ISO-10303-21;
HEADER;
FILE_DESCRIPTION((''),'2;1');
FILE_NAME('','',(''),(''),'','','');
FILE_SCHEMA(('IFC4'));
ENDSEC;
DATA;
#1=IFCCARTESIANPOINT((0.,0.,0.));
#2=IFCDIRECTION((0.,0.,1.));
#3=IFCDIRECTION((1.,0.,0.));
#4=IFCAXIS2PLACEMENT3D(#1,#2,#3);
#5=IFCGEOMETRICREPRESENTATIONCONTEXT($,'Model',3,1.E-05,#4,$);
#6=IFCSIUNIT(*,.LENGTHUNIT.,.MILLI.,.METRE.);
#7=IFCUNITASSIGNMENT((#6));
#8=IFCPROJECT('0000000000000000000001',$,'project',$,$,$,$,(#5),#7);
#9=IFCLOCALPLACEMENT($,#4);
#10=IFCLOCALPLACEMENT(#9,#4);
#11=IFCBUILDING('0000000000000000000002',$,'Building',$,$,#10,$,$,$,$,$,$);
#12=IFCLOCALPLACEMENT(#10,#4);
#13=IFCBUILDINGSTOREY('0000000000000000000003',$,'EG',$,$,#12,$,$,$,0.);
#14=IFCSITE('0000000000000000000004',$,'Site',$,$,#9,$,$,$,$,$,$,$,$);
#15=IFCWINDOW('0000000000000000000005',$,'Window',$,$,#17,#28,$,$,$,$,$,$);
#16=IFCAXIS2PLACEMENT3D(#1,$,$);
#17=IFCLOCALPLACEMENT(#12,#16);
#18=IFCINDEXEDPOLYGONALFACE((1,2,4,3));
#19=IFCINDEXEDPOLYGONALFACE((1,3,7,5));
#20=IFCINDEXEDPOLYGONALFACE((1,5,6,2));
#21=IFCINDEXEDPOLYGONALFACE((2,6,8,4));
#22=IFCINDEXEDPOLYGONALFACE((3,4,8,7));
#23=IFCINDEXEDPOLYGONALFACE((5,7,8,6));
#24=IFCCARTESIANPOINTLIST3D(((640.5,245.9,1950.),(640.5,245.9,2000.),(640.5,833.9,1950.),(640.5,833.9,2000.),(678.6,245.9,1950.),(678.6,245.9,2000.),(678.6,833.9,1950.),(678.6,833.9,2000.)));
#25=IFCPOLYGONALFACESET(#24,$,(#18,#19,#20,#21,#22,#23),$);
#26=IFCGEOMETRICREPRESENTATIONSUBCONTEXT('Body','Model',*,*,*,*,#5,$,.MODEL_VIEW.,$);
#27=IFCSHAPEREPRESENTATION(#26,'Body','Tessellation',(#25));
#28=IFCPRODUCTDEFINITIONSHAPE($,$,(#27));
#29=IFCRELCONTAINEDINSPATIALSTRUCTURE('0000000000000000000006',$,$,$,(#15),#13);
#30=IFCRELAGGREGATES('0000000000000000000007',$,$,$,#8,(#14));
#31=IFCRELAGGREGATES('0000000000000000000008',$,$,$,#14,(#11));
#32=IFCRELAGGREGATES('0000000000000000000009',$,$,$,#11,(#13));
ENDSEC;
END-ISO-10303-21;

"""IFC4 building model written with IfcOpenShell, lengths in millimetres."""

from ifc_helpers import new_model, si_unit, frame, origin_with_axes, place, context, subcontext, project, spatial, rectangle, extrude, element, save


model = new_model("IFC4")

# Units and contexts
model_context = context("Model", 3, precision=1e-05, world=origin_with_axes())
body_context = subcontext(model_context, "Body", "Model", "MODEL_VIEW")
ifc_project = project(units=[si_unit("LENGTHUNIT", "METRE", prefix="MILLI")], contexts=[model_context])

# Site, building, storey
site_placement = place(None, origin_with_axes())
site = spatial("IfcSite", under=ifc_project, at=site_placement, Name="Site")
building_placement = place(site_placement, origin_with_axes())
building = spatial("IfcBuilding", under=site, at=building_placement, Name="Building")
storey_placement = place(building_placement, origin_with_axes())
storey = spatial("IfcBuildingStorey", under=building, at=storey_placement, Name="EG", Elevation=0.0)

# Window
window_1_placement = place(storey_placement, origin_with_axes())
element("IfcWindow", 1, at=window_1_placement, inside=storey, Name="Window", context=body_context, shape_type="SweptSolid", body=[
    extrude(rectangle(XDim=588.0, YDim=38.1), frame((659.6, 539.9, 1950.0), z_axis=(0.0, 0.0, 1.0), x_axis=(0.0, 1.0, 0.0)), (0.0, 0.0, 1.0), 50.0),
])

save(model, "model.ifc")
